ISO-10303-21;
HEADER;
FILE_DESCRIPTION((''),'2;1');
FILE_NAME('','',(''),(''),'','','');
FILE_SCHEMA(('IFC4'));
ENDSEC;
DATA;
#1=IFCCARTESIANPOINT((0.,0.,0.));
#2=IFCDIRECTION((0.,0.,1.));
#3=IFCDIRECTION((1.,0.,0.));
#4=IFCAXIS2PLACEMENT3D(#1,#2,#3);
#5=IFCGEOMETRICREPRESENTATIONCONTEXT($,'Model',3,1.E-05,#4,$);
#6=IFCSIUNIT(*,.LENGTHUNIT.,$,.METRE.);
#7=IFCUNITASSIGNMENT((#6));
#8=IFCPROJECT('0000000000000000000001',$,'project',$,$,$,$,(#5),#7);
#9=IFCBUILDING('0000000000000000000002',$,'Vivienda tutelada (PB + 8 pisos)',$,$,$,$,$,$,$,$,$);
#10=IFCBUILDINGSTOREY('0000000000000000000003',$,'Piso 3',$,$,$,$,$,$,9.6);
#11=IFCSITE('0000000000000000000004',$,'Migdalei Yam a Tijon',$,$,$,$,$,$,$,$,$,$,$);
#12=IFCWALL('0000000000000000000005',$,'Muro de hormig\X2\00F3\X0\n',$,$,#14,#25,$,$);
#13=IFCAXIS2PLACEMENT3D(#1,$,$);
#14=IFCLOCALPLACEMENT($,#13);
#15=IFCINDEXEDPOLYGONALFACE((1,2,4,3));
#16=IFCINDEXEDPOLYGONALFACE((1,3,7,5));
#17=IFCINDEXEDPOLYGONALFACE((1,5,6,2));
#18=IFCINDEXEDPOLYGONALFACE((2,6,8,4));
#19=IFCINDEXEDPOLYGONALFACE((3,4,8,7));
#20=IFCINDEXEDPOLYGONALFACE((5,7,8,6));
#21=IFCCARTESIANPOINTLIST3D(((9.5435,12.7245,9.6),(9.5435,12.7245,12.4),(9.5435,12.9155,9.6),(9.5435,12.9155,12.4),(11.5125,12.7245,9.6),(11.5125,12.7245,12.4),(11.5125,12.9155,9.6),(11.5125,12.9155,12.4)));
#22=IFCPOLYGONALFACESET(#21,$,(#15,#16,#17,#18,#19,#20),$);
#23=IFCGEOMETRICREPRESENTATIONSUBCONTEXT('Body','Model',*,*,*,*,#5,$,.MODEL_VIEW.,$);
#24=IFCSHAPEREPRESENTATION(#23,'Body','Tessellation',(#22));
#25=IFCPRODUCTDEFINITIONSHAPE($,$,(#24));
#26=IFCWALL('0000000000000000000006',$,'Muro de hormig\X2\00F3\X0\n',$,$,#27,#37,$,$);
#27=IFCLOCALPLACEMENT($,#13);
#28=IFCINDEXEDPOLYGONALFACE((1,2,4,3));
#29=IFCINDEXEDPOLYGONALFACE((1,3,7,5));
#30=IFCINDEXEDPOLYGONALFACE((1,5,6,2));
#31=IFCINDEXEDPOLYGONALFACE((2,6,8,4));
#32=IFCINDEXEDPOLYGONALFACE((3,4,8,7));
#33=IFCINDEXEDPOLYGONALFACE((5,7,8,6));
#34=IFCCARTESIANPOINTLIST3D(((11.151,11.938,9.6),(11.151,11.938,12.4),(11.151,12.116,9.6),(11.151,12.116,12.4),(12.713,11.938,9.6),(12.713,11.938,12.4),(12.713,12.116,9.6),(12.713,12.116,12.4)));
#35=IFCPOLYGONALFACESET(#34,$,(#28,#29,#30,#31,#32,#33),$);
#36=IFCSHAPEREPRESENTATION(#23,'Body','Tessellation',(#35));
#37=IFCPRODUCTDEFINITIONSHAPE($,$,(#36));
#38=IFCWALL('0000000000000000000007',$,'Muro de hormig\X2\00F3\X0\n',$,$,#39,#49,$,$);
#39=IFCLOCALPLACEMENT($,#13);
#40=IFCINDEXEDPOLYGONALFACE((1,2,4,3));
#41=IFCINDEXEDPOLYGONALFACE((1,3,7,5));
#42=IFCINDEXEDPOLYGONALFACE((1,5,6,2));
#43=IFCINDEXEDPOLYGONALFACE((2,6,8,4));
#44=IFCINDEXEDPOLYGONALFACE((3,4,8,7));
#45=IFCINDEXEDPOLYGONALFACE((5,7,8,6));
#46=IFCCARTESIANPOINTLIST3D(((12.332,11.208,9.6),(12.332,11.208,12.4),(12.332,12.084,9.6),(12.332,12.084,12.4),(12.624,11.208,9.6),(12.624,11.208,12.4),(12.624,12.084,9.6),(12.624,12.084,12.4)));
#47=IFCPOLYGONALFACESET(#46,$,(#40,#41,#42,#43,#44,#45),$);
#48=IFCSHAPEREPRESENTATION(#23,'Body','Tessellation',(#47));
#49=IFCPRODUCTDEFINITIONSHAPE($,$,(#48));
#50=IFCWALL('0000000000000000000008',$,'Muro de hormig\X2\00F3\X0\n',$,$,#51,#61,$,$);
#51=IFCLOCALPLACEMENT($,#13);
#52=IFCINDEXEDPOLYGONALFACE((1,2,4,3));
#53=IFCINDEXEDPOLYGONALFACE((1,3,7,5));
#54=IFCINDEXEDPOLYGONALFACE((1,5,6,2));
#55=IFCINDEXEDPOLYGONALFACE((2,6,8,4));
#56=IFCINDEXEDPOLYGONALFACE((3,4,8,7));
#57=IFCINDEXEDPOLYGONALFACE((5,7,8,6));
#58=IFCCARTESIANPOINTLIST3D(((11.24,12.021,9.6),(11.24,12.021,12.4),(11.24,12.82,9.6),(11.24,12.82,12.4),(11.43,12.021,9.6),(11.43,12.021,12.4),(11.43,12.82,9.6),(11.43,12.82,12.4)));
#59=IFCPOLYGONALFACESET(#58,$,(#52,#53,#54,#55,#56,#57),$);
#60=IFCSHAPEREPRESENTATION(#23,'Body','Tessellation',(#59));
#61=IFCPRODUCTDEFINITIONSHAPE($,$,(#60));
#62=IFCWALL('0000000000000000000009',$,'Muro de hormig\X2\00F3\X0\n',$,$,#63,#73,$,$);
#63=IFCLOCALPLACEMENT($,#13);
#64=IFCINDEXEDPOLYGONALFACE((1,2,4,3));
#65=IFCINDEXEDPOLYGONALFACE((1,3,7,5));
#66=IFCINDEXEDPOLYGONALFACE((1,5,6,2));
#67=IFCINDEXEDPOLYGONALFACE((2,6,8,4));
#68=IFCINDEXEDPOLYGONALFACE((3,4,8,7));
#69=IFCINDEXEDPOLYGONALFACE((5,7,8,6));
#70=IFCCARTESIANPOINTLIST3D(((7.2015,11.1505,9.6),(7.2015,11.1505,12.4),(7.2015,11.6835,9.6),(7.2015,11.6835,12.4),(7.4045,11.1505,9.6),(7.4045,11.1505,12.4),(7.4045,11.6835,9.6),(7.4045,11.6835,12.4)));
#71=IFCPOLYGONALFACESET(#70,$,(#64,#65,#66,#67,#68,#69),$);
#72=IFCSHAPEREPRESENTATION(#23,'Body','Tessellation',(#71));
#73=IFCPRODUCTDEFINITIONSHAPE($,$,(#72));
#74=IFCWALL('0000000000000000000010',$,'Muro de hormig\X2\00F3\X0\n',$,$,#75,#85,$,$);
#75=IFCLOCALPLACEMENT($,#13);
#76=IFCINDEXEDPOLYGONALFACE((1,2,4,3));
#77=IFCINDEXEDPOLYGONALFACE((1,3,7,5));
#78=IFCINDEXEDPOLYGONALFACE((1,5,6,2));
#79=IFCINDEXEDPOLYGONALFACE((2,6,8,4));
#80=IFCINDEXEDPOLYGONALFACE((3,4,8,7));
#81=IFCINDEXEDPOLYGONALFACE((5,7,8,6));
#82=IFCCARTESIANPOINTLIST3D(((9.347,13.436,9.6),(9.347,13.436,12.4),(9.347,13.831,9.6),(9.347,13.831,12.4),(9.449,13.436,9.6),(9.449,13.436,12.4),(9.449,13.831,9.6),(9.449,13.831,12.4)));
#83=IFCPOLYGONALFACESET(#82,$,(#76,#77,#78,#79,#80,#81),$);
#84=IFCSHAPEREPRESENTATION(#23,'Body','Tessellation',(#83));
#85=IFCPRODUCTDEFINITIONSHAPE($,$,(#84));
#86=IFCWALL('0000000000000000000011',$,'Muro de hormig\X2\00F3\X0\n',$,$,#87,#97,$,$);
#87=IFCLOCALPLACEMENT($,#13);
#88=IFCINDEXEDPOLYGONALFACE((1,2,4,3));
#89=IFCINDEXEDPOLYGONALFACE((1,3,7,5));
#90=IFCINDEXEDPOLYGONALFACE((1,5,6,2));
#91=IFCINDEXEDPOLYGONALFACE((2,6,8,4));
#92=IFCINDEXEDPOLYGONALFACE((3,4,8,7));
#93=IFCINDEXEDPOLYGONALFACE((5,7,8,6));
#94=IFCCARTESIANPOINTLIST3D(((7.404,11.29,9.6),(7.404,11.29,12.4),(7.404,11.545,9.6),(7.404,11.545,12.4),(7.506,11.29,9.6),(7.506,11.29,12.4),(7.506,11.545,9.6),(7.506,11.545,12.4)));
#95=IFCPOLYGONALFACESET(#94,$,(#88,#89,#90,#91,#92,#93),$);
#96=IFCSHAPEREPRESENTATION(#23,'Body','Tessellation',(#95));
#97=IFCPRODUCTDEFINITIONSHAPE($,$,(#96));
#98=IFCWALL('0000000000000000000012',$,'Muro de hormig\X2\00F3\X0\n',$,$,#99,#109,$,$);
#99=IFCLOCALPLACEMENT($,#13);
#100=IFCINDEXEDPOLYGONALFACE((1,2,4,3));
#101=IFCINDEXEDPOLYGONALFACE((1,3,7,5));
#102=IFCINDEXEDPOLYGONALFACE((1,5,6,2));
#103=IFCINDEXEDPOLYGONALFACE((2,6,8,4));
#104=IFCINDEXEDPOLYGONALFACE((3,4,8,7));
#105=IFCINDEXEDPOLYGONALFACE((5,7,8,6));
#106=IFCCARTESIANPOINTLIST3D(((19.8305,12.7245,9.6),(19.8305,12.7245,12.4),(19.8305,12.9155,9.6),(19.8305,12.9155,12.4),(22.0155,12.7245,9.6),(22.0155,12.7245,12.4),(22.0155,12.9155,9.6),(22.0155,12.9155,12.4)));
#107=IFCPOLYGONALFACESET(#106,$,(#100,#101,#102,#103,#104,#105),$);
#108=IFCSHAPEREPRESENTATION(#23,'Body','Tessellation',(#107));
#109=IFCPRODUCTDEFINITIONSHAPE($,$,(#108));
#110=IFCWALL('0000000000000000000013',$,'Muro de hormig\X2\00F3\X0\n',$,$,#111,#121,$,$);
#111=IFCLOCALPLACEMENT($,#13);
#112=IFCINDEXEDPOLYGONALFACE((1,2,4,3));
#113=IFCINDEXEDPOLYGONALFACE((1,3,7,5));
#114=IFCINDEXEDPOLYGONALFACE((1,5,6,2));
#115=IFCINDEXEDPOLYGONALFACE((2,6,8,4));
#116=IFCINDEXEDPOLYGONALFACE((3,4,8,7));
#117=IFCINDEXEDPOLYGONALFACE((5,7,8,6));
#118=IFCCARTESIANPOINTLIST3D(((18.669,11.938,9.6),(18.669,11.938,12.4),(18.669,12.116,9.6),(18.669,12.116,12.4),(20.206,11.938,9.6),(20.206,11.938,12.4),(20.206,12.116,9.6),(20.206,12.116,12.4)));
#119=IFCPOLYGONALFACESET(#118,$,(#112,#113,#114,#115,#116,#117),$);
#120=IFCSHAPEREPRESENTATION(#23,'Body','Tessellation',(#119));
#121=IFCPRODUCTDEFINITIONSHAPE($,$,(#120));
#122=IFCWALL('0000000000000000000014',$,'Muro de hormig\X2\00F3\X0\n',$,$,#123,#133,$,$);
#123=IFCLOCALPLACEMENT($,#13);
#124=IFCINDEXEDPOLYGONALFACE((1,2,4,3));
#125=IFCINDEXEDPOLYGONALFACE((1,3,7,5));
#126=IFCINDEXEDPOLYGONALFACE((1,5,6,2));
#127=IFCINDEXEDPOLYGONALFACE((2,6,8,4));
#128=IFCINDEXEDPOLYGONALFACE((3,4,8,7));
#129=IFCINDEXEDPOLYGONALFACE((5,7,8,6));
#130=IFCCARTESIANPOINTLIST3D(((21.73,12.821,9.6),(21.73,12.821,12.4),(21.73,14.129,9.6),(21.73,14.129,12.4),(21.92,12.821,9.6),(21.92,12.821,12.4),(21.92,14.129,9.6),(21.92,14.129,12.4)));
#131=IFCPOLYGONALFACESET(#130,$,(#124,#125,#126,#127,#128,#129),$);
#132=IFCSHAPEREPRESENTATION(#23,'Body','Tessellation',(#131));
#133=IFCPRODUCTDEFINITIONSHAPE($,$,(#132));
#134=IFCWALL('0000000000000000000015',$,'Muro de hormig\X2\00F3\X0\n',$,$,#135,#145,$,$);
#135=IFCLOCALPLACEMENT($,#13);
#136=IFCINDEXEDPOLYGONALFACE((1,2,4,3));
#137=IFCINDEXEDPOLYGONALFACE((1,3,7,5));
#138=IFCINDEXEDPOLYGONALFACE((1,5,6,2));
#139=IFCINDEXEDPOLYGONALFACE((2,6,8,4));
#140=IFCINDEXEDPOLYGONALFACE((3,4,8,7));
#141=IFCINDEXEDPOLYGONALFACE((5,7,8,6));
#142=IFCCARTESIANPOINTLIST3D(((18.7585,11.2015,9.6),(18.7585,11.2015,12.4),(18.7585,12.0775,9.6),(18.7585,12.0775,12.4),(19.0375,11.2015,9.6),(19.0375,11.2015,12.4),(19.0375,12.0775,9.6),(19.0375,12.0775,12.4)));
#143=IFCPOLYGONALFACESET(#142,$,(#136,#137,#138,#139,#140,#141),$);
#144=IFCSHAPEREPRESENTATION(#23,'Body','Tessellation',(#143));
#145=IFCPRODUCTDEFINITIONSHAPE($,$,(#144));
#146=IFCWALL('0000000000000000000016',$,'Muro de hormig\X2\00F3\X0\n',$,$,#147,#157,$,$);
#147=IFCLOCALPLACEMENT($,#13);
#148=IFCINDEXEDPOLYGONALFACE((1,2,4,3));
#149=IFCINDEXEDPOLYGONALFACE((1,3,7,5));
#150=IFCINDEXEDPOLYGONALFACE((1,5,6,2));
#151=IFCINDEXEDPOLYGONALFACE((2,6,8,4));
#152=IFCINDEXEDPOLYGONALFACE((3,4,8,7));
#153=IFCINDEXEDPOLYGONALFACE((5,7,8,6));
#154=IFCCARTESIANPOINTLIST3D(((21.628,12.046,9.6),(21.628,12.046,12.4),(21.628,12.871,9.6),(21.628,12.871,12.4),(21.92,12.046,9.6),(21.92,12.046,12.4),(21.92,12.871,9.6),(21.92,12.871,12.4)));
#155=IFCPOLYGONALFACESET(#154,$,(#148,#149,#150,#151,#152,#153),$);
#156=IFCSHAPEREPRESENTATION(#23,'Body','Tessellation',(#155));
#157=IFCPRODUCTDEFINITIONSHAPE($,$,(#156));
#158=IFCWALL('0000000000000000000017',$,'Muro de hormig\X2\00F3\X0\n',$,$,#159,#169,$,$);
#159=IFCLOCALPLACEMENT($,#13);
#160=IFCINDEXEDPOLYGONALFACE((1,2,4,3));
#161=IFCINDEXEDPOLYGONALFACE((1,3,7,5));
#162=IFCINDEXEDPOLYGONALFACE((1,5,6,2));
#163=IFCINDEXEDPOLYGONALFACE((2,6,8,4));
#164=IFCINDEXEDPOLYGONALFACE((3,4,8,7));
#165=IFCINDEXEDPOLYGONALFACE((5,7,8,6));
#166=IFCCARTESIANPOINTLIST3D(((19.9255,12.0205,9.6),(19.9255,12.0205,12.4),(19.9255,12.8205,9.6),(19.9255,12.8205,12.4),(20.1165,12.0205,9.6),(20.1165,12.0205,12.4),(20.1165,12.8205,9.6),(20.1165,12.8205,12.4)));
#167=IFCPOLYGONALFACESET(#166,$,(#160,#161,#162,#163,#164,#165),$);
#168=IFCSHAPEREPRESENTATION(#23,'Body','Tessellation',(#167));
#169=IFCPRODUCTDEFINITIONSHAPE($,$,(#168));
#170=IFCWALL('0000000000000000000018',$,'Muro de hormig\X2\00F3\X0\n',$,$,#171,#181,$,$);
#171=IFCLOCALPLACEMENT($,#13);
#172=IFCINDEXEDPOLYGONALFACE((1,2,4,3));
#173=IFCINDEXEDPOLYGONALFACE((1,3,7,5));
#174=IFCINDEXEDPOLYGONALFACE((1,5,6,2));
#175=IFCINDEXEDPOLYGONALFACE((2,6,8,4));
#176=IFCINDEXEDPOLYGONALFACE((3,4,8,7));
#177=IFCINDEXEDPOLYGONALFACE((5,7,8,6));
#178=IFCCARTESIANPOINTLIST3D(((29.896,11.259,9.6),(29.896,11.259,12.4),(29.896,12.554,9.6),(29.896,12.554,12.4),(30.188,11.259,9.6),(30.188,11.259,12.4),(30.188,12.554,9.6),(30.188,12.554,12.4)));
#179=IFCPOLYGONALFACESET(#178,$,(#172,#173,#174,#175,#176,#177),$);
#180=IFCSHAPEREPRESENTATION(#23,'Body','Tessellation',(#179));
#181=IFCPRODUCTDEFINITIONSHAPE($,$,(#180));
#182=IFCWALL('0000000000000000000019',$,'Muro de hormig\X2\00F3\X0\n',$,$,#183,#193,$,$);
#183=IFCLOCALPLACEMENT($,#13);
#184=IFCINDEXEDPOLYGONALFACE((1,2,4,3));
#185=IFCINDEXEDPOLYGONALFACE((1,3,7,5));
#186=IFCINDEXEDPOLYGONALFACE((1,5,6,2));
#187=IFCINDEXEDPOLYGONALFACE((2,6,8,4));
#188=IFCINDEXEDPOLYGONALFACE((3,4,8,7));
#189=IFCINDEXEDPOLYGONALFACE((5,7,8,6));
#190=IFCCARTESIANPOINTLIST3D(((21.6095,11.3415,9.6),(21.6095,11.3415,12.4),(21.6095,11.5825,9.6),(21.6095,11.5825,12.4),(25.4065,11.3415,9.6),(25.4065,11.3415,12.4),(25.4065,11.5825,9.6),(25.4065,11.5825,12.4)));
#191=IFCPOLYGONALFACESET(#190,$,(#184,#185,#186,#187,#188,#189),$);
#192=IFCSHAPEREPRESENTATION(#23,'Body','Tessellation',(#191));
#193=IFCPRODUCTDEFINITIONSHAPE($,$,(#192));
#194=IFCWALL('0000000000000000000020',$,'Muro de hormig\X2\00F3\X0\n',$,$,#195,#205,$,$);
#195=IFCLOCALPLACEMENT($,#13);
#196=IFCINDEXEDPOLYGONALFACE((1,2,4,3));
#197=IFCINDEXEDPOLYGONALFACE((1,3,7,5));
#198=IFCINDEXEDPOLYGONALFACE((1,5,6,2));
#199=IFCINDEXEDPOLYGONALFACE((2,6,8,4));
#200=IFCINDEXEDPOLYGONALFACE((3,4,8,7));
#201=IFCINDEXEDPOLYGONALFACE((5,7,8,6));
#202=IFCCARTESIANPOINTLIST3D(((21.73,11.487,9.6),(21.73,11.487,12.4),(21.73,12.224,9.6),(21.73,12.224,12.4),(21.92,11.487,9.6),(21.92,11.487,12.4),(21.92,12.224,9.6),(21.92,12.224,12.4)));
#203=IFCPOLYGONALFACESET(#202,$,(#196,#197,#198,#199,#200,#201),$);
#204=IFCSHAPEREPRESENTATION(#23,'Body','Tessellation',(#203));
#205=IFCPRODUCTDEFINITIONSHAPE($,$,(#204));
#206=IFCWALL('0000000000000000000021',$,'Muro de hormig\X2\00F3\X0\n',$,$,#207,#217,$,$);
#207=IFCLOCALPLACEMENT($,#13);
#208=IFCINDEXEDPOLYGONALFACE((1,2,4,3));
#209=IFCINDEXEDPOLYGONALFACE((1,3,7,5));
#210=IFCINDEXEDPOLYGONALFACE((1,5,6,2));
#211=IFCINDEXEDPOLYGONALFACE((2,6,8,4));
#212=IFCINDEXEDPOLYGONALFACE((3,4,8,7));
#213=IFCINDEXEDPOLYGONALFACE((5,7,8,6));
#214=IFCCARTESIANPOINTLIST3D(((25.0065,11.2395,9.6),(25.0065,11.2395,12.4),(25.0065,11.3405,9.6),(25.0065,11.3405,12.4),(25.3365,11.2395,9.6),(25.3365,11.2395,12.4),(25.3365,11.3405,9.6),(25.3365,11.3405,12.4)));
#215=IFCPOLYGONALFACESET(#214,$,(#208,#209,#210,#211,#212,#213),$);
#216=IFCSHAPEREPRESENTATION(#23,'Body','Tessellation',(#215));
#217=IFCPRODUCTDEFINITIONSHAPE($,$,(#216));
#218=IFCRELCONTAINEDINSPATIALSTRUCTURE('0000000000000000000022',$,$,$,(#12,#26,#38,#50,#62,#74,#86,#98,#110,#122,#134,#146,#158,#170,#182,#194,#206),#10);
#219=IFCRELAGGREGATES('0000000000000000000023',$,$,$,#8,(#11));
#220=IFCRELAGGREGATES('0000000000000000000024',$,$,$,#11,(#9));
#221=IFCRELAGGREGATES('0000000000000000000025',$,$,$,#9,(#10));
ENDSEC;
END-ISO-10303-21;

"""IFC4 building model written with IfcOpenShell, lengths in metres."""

from ifc_helpers import new_model, si_unit, frame, origin_with_axes, context, subcontext, project, spatial, line, indexed_curve, outline, extrude, element, save


model = new_model("IFC4")

# Units and contexts
model_context = context("Model", 3, precision=1e-05, world=origin_with_axes())
body_context = subcontext(model_context, "Body", "Model", "MODEL_VIEW")
ifc_project = project(units=[si_unit("LENGTHUNIT", "METRE")], contexts=[model_context])

# Site, building, storey
site = spatial("IfcSite", under=ifc_project, Name="Migdalei Yam a Tijon")
building = spatial("IfcBuilding", under=site, Name="Vivienda tutelada (PB + 8 pisos)")
storey = spatial("IfcBuildingStorey", under=building, Name="Piso 3", Elevation=9.6)

# Walls
element("IfcWall", 1, inside=storey, Name="Muro de hormigón", context=body_context, shape_type="SweptSolid", body=[
    extrude(outline(indexed_curve([(0.0, 0.0), (1.969, 0.0), (1.969, 0.191), (0.0, 0.191)], segments=[line(1, 2, 3, 4, 1)])), frame((9.5435, 12.7245, 9.6), z_axis=(0.0, 0.0, 1.0), x_axis=(1.0, 0.0, 0.0)), (0.0, 0.0, 1.0), 2.8),
])
element("IfcWall", 2, inside=storey, Name="Muro de hormigón", context=body_context, shape_type="SweptSolid", body=[
    extrude(outline(indexed_curve([(0.0, 0.0), (1.562, 0.0), (1.562, 0.178), (0.0, 0.178)], segments=[line(1, 2, 3, 4, 1)])), frame((11.151, 11.938, 9.6), z_axis=(0.0, 0.0, 1.0), x_axis=(1.0, 0.0, 0.0)), (0.0, 0.0, 1.0), 2.8),
])
element("IfcWall", 3, inside=storey, Name="Muro de hormigón", context=body_context, shape_type="SweptSolid", body=[
    extrude(outline(indexed_curve([(0.0, 0.0), (0.292, 0.0), (0.292, 0.876), (0.0, 0.876)], segments=[line(1, 2, 3, 4, 1)])), frame((12.332, 11.208, 9.6), z_axis=(0.0, 0.0, 1.0), x_axis=(1.0, 0.0, 0.0)), (0.0, 0.0, 1.0), 2.8),
])
element("IfcWall", 4, inside=storey, Name="Muro de hormigón", context=body_context, shape_type="SweptSolid", body=[
    extrude(outline(indexed_curve([(0.0, 0.0), (0.19, 0.0), (0.19, 0.799), (0.0, 0.799)], segments=[line(1, 2, 3, 4, 1)])), frame((11.24, 12.021, 9.6), z_axis=(0.0, 0.0, 1.0), x_axis=(1.0, 0.0, 0.0)), (0.0, 0.0, 1.0), 2.8),
])
element("IfcWall", 5, inside=storey, Name="Muro de hormigón", context=body_context, shape_type="SweptSolid", body=[
    extrude(outline(indexed_curve([(0.0, 0.0), (0.203, 0.0), (0.203, 0.533), (0.0, 0.533)], segments=[line(1, 2, 3, 4, 1)])), frame((7.2015, 11.1505, 9.6), z_axis=(0.0, 0.0, 1.0), x_axis=(1.0, 0.0, 0.0)), (0.0, 0.0, 1.0), 2.8),
])
element("IfcWall", 6, inside=storey, Name="Muro de hormigón", context=body_context, shape_type="SweptSolid", body=[
    extrude(outline(indexed_curve([(0.0, 0.0), (0.102, 0.0), (0.102, 0.395), (0.0, 0.395)], segments=[line(1, 2, 3, 4, 1)])), frame((9.347, 13.436, 9.6), z_axis=(0.0, 0.0, 1.0), x_axis=(1.0, 0.0, 0.0)), (0.0, 0.0, 1.0), 2.8),
])
element("IfcWall", 7, inside=storey, Name="Muro de hormigón", context=body_context, shape_type="SweptSolid", body=[
    extrude(outline(indexed_curve([(0.0, 0.0), (0.102, 0.0), (0.102, 0.255), (0.0, 0.255)], segments=[line(1, 2, 3, 4, 1)])), frame((7.404, 11.29, 9.6), z_axis=(0.0, 0.0, 1.0), x_axis=(1.0, 0.0, 0.0)), (0.0, 0.0, 1.0), 2.8),
])
element("IfcWall", 8, inside=storey, Name="Muro de hormigón", context=body_context, shape_type="SweptSolid", body=[
    extrude(outline(indexed_curve([(0.0, 0.0), (2.185, 0.0), (2.185, 0.191), (0.0, 0.191)], segments=[line(1, 2, 3, 4, 1)])), frame((19.8305, 12.7245, 9.6), z_axis=(0.0, 0.0, 1.0), x_axis=(1.0, 0.0, 0.0)), (0.0, 0.0, 1.0), 2.8),
])
element("IfcWall", 9, inside=storey, Name="Muro de hormigón", context=body_context, shape_type="SweptSolid", body=[
    extrude(outline(indexed_curve([(0.0, 0.0), (1.537, 0.0), (1.537, 0.178), (0.0, 0.178)], segments=[line(1, 2, 3, 4, 1)])), frame((18.669, 11.938, 9.6), z_axis=(0.0, 0.0, 1.0), x_axis=(1.0, 0.0, 0.0)), (0.0, 0.0, 1.0), 2.8),
])
element("IfcWall", 10, inside=storey, Name="Muro de hormigón", context=body_context, shape_type="SweptSolid", body=[
    extrude(outline(indexed_curve([(0.0, 0.0), (0.19, 0.0), (0.19, 1.308), (0.0, 1.308)], segments=[line(1, 2, 3, 4, 1)])), frame((21.73, 12.821, 9.6), z_axis=(0.0, 0.0, 1.0), x_axis=(1.0, 0.0, 0.0)), (0.0, 0.0, 1.0), 2.8),
])
element("IfcWall", 11, inside=storey, Name="Muro de hormigón", context=body_context, shape_type="SweptSolid", body=[
    extrude(outline(indexed_curve([(0.0, 0.0), (0.279, 0.0), (0.279, 0.876), (0.0, 0.876)], segments=[line(1, 2, 3, 4, 1)])), frame((18.7585, 11.2015, 9.6), z_axis=(0.0, 0.0, 1.0), x_axis=(1.0, 0.0, 0.0)), (0.0, 0.0, 1.0), 2.8),
])
element("IfcWall", 12, inside=storey, Name="Muro de hormigón", context=body_context, shape_type="SweptSolid", body=[
    extrude(outline(indexed_curve([(0.0, 0.0), (0.292, 0.0), (0.292, 0.825), (0.0, 0.825)], segments=[line(1, 2, 3, 4, 1)])), frame((21.628, 12.046, 9.6), z_axis=(0.0, 0.0, 1.0), x_axis=(1.0, 0.0, 0.0)), (0.0, 0.0, 1.0), 2.8),
])
element("IfcWall", 13, inside=storey, Name="Muro de hormigón", context=body_context, shape_type="SweptSolid", body=[
    extrude(outline(indexed_curve([(0.0, 0.0), (0.191, 0.0), (0.191, 0.8), (0.0, 0.8)], segments=[line(1, 2, 3, 4, 1)])), frame((19.9255, 12.0205, 9.6), z_axis=(0.0, 0.0, 1.0), x_axis=(1.0, 0.0, 0.0)), (0.0, 0.0, 1.0), 2.8),
])
element("IfcWall", 14, inside=storey, Name="Muro de hormigón", context=body_context, shape_type="SweptSolid", body=[
    extrude(outline(indexed_curve([(0.0, 0.0), (0.292, 0.0), (0.292, 1.295), (0.0, 1.295)], segments=[line(1, 2, 3, 4, 1)])), frame((29.896, 11.259, 9.6), z_axis=(0.0, 0.0, 1.0), x_axis=(1.0, 0.0, 0.0)), (0.0, 0.0, 1.0), 2.8),
])
element("IfcWall", 15, inside=storey, Name="Muro de hormigón", context=body_context, shape_type="SweptSolid", body=[
    extrude(outline(indexed_curve([(0.0, 0.0), (3.797, 0.0), (3.797, 0.241), (0.0, 0.241)], segments=[line(1, 2, 3, 4, 1)])), frame((21.6095, 11.3415, 9.6), z_axis=(0.0, 0.0, 1.0), x_axis=(1.0, 0.0, 0.0)), (0.0, 0.0, 1.0), 2.8),
])
element("IfcWall", 16, inside=storey, Name="Muro de hormigón", context=body_context, shape_type="SweptSolid", body=[
    extrude(outline(indexed_curve([(0.0, 0.0), (0.19, 0.0), (0.19, 0.737), (0.0, 0.737)], segments=[line(1, 2, 3, 4, 1)])), frame((21.73, 11.487, 9.6), z_axis=(0.0, 0.0, 1.0), x_axis=(1.0, 0.0, 0.0)), (0.0, 0.0, 1.0), 2.8),
])
element("IfcWall", 17, inside=storey, Name="Muro de hormigón", context=body_context, shape_type="SweptSolid", body=[
    extrude(outline(indexed_curve([(0.0, 0.0), (0.33, 0.0), (0.33, 0.101), (0.0, 0.101)], segments=[line(1, 2, 3, 4, 1)])), frame((25.0065, 11.2395, 9.6), z_axis=(0.0, 0.0, 1.0), x_axis=(1.0, 0.0, 0.0)), (0.0, 0.0, 1.0), 2.8),
])

save(model, "model.ifc")
